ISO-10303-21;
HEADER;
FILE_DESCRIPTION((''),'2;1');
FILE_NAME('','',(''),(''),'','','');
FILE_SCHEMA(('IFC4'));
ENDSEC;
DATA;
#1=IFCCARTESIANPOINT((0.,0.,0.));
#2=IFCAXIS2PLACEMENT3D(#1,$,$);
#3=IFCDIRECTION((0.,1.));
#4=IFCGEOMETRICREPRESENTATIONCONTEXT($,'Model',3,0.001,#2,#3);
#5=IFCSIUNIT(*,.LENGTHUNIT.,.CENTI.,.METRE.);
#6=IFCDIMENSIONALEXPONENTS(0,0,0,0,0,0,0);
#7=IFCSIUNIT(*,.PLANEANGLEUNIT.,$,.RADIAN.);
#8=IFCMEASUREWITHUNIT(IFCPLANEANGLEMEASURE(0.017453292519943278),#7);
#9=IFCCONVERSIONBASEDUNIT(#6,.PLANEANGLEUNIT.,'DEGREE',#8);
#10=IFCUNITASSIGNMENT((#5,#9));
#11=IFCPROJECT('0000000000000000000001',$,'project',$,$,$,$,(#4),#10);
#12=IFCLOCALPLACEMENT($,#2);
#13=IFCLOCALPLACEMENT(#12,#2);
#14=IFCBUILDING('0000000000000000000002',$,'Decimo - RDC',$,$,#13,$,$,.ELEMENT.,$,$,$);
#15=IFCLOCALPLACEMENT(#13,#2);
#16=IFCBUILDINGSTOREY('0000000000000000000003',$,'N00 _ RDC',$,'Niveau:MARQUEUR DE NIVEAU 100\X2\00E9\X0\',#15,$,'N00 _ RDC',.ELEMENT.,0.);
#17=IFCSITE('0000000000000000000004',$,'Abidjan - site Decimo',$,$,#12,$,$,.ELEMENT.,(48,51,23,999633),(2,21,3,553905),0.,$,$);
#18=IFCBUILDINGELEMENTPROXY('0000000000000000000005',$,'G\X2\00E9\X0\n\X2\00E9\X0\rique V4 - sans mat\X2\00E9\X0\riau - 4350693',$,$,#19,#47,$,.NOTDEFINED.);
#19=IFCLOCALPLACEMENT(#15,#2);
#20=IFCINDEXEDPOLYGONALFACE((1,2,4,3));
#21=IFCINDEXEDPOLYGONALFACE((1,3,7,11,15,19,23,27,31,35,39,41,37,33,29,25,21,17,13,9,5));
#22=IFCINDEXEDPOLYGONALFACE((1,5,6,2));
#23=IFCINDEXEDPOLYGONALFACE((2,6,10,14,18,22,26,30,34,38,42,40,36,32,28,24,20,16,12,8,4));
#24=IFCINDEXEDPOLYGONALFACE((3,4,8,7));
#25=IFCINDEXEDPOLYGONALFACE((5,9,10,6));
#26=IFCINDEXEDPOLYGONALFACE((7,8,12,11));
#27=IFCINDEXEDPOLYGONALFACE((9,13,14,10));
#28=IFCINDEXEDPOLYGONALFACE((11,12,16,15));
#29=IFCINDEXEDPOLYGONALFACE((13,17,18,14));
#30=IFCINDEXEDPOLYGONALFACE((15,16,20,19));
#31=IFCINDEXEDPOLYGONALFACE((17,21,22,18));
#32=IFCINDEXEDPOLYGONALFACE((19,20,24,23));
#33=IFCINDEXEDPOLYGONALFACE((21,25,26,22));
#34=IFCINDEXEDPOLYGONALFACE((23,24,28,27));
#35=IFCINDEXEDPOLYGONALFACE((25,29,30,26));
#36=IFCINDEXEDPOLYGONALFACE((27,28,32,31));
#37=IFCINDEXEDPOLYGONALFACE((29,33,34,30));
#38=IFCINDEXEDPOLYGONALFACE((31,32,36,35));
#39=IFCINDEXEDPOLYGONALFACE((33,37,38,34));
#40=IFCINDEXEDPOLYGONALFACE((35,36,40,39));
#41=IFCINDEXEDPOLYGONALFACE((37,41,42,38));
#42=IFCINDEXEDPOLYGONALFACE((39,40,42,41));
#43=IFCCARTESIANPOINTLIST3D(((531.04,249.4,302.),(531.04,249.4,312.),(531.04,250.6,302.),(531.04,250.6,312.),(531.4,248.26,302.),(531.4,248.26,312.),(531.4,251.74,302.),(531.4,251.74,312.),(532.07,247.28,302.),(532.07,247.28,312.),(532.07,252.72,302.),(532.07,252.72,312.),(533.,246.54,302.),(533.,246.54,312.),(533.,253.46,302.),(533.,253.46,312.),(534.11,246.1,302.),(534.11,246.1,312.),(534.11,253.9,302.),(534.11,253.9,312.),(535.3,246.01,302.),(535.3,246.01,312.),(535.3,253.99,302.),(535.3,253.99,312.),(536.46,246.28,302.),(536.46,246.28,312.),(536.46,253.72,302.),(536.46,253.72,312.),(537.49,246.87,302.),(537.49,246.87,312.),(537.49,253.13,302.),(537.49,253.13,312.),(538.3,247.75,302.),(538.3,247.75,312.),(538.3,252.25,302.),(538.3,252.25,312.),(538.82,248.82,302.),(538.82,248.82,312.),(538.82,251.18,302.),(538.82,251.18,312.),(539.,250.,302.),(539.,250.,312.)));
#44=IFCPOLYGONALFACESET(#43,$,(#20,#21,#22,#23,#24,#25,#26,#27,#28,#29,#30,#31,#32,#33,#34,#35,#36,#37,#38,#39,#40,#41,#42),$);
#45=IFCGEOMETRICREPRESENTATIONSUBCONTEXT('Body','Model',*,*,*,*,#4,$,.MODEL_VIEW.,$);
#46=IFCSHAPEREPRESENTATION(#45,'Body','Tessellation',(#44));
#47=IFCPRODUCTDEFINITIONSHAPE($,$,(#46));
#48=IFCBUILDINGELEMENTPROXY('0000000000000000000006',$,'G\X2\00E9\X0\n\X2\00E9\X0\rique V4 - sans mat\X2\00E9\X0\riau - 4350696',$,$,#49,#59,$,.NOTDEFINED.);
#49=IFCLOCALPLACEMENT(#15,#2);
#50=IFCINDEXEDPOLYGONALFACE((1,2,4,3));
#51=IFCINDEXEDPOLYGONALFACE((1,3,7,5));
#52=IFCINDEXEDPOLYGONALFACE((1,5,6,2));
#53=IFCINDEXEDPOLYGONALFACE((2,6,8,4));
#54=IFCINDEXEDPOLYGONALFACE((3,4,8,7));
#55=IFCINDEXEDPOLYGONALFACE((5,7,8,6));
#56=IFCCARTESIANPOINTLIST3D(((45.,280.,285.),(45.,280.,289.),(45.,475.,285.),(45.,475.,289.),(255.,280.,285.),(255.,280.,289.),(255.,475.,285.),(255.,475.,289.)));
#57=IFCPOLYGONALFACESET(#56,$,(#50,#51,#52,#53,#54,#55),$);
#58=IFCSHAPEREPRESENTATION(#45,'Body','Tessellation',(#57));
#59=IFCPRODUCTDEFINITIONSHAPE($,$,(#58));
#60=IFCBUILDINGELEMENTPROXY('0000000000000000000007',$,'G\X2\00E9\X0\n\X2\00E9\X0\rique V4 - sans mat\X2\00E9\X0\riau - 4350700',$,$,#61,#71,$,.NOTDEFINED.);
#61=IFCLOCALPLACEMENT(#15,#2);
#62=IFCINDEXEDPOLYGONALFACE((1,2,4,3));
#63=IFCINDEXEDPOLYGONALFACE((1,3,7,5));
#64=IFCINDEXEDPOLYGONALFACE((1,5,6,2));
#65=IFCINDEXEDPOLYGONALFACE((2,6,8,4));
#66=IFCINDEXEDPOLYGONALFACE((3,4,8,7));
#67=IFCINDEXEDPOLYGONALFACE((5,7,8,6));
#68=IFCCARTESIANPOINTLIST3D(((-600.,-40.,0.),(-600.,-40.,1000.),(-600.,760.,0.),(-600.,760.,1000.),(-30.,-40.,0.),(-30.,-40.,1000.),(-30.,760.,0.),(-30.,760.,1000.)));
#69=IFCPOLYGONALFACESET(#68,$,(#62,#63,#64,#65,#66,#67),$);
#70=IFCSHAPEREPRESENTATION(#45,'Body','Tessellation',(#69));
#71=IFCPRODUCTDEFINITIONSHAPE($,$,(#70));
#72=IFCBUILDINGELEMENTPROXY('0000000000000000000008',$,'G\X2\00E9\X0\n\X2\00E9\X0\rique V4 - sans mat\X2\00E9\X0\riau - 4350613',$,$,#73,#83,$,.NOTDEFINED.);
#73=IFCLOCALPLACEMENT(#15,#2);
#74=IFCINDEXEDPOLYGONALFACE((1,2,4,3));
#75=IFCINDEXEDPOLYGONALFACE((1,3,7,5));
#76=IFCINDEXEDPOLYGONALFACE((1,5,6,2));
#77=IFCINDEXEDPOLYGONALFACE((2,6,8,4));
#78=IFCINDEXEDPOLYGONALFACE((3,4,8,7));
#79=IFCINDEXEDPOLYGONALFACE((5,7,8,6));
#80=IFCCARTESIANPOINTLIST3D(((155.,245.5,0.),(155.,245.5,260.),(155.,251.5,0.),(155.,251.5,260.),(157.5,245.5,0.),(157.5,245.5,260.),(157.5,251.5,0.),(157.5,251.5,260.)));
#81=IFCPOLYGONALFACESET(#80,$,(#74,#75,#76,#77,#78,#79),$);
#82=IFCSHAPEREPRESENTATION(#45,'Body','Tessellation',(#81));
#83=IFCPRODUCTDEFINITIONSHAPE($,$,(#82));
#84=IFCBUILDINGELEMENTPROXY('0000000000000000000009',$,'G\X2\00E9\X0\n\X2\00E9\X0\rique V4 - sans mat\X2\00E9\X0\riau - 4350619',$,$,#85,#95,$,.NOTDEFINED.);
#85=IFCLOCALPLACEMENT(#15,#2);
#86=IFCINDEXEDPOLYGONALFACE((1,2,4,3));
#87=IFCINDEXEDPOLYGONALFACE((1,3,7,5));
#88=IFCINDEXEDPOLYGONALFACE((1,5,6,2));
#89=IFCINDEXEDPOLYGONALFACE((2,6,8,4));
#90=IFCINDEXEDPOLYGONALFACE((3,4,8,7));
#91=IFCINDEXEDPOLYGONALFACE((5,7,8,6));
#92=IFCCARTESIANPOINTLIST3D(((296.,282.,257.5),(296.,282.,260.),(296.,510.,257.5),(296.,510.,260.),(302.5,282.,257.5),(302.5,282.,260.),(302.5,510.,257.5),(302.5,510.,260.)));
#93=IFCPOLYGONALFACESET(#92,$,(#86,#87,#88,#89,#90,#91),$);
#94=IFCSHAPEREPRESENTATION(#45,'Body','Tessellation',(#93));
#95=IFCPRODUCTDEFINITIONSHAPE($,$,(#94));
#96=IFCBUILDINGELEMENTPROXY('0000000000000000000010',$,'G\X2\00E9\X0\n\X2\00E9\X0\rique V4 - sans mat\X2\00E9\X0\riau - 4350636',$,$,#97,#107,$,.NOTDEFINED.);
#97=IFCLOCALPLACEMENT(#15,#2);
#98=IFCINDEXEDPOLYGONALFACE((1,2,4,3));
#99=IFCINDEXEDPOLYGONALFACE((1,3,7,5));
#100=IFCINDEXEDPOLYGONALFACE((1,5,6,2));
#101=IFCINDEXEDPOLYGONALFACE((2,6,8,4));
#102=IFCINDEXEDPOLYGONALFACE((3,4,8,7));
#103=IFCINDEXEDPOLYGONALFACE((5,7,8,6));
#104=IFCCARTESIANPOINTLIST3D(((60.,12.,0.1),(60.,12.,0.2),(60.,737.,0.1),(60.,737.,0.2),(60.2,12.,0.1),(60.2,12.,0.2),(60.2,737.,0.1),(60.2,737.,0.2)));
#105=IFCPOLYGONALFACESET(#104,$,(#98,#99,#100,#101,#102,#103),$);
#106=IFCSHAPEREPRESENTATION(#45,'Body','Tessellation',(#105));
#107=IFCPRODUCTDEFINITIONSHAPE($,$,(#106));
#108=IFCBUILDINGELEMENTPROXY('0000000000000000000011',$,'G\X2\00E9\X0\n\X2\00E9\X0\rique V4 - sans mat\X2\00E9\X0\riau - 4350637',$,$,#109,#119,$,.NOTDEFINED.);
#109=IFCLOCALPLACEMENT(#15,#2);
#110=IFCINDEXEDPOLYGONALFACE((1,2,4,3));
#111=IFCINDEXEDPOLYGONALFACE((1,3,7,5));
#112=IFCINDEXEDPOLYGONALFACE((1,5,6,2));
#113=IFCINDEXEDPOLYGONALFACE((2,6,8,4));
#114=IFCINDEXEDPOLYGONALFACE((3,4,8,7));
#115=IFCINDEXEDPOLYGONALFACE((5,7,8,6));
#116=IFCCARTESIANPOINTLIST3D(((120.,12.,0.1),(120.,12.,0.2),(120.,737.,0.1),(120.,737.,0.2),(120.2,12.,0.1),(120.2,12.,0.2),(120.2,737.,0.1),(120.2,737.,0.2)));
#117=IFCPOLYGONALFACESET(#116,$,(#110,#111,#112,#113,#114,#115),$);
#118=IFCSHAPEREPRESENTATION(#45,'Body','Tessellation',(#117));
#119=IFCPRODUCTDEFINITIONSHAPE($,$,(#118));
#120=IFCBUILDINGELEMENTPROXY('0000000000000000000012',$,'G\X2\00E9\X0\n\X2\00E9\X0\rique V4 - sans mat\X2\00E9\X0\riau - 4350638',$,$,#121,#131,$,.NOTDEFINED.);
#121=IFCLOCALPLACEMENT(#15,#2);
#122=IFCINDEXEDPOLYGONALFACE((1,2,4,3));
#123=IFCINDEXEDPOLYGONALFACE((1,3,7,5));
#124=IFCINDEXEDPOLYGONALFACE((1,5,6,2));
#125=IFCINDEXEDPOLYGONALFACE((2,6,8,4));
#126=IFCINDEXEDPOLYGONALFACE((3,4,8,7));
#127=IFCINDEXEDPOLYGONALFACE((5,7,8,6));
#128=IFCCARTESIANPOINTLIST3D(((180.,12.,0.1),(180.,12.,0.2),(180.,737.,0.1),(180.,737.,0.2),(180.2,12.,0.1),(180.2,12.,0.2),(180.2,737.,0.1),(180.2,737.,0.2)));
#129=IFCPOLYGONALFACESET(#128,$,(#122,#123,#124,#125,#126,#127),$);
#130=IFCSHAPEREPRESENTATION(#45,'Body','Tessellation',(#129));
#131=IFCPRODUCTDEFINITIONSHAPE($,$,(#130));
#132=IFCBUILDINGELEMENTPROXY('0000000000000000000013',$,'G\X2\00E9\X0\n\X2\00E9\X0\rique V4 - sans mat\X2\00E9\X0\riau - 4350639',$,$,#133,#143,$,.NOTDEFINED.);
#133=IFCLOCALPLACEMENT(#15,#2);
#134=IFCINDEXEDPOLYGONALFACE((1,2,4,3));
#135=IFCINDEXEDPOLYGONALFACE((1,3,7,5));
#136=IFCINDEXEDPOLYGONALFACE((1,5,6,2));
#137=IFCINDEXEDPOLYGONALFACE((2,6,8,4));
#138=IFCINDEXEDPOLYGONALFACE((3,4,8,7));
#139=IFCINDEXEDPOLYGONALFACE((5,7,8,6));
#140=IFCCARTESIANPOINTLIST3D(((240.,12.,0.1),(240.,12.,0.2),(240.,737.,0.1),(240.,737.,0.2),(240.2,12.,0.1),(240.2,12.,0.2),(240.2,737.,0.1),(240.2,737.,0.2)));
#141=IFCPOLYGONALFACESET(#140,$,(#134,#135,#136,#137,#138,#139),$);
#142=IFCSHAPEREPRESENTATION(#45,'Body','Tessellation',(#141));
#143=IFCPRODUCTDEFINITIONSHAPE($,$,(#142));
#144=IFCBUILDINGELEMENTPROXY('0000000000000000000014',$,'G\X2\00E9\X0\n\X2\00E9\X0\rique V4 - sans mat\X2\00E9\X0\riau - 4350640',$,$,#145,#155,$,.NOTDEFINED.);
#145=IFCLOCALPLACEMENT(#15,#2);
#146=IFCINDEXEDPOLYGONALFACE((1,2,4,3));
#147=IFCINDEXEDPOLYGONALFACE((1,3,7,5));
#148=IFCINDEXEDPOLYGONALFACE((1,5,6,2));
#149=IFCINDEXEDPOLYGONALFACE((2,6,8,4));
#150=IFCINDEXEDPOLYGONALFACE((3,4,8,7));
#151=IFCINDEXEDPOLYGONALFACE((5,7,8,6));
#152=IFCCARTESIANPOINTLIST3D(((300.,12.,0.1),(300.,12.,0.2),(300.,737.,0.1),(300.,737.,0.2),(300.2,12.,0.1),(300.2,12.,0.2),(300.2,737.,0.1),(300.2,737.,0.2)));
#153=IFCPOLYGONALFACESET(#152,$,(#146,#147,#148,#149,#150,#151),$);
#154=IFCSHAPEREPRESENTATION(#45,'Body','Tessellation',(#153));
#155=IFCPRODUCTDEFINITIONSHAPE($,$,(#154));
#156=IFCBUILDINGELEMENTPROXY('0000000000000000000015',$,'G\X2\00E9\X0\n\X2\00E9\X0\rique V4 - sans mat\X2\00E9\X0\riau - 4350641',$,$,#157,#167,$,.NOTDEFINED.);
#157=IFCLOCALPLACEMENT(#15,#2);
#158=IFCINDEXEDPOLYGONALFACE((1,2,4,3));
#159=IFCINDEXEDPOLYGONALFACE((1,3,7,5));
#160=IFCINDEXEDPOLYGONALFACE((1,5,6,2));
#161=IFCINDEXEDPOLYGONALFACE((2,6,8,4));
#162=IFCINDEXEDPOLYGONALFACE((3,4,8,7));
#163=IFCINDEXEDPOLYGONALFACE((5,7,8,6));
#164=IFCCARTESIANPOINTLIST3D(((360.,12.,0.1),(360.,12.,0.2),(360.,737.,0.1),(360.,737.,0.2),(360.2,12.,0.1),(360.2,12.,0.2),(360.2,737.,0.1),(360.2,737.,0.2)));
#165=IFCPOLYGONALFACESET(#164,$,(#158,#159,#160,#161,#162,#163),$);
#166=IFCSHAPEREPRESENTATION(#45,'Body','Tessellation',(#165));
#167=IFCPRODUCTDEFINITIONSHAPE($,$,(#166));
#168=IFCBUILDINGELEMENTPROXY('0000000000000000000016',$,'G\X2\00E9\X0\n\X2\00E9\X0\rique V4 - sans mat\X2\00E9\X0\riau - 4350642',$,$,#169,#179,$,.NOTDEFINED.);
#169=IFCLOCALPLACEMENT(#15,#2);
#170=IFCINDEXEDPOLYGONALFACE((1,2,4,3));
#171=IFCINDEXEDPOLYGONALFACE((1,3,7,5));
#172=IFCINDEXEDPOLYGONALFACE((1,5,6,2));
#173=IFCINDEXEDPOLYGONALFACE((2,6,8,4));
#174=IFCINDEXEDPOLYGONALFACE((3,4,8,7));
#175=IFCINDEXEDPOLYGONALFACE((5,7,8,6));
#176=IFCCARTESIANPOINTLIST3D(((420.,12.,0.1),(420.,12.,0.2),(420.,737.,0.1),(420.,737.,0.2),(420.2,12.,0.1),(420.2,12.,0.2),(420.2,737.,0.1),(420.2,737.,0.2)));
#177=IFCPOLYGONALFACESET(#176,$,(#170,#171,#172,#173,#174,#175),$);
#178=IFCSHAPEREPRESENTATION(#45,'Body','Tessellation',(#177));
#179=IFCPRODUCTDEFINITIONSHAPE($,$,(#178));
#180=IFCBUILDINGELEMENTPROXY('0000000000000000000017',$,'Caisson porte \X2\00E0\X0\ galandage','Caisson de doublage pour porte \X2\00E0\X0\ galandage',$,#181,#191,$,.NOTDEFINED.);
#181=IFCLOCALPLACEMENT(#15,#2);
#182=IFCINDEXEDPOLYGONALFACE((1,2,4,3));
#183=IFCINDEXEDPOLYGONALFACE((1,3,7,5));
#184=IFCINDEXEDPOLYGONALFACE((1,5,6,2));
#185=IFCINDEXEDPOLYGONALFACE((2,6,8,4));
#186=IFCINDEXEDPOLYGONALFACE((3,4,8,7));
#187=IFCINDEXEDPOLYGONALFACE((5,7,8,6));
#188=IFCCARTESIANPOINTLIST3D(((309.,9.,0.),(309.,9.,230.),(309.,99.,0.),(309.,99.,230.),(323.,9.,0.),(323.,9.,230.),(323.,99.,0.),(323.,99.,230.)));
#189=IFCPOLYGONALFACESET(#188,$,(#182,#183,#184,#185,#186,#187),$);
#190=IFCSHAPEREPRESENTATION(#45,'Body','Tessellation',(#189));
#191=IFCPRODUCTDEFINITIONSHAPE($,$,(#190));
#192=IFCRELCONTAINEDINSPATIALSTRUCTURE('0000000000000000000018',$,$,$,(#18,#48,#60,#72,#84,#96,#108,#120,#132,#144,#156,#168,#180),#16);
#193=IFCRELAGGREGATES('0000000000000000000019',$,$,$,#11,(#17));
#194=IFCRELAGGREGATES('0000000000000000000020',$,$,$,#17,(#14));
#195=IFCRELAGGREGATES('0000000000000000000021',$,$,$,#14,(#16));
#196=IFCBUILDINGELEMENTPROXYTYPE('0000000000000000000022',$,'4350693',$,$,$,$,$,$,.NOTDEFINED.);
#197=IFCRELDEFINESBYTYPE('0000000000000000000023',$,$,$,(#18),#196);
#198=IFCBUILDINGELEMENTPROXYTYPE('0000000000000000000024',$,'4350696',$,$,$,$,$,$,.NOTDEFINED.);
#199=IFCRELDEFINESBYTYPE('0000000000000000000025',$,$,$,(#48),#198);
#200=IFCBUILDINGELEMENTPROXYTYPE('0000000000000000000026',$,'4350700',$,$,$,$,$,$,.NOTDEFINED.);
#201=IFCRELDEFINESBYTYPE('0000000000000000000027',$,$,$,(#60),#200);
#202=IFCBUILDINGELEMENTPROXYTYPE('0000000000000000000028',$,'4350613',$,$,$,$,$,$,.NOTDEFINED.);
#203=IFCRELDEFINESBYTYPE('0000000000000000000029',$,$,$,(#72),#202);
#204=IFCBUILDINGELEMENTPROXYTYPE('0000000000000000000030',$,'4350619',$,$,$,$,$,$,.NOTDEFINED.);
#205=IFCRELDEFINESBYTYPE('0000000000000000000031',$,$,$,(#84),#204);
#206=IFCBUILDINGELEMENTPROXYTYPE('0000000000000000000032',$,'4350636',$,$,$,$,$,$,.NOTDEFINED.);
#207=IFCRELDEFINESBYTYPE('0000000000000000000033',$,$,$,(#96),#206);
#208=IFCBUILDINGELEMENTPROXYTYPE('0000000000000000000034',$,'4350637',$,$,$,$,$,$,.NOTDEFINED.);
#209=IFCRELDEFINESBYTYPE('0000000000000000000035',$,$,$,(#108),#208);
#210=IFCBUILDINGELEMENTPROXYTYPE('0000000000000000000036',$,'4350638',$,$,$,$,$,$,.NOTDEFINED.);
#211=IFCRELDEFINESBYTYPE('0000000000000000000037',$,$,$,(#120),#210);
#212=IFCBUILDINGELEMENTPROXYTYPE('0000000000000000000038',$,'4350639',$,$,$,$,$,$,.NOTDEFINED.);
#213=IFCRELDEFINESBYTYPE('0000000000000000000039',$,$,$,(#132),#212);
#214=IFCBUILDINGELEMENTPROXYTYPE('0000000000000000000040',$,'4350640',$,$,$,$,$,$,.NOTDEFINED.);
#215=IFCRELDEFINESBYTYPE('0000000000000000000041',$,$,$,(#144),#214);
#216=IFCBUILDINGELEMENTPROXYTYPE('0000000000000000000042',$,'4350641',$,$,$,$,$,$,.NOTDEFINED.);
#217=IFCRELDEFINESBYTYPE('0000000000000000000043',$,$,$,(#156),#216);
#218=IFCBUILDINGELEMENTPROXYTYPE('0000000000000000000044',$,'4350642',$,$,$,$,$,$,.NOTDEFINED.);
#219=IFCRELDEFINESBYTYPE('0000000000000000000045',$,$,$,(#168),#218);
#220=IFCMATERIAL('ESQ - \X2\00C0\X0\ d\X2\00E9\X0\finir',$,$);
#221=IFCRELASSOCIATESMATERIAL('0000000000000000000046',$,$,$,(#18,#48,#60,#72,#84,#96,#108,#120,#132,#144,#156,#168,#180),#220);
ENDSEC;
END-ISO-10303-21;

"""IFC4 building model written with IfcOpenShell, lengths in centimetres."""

from ifc_helpers import new_model, entity, si_unit, converted_unit, direction, frame, frame_2d, origin, origin_with_axes, origin_2d_with_axis, place, context, subcontext, project, spatial, rectangle, circle, extrude, material, type_object, element, save


model = new_model("IFC4")

# Units and contexts
model_context = context("Model", 3, precision=0.001, world=origin(), true_north=direction((0.0, 1.0)))
body_context = subcontext(model_context, "Body", "Model", "MODEL_VIEW")
ifc_project = project(units=[si_unit("LENGTHUNIT", "METRE", prefix="CENTI"), converted_unit("PLANEANGLEUNIT", "DEGREE", entity("IfcPlaneAngleMeasure", 0.017453292519943278), si_unit("PLANEANGLEUNIT", "RADIAN"), dimensions=[0, 0, 0, 0, 0, 0, 0])], contexts=[model_context])

# Site, building, storey
site_placement = place(None, origin())
site = spatial("IfcSite", under=ifc_project, at=site_placement, Name="Abidjan - site Decimo", CompositionType="ELEMENT", RefLatitude=(48, 51, 23, 999633), RefLongitude=(2, 21, 3, 553905), RefElevation=0.0)
building_placement = place(site_placement, origin())
building = spatial("IfcBuilding", under=site, at=building_placement, Name="Decimo - RDC", CompositionType="ELEMENT")
storey_placement = place(building_placement, origin())
storey = spatial("IfcBuildingStorey", under=building, at=storey_placement, Name="N00 _ RDC", ObjectType="Niveau:MARQUEUR DE NIVEAU 100é", LongName="N00 _ RDC", CompositionType="ELEMENT", Elevation=0.0)

# Building element proxies
ifc_material_1 = material(Name="ESQ - À définir")
building_element_proxy_type_1 = type_object("IfcBuildingElementProxyType", Name="4350693", PredefinedType="NOTDEFINED")
proxy_1_placement = place(storey_placement, origin())
element("IfcBuildingElementProxy", 1, at=proxy_1_placement, inside=storey, type_object=building_element_proxy_type_1, material=ifc_material_1, Name="Générique V4 - sans matériau - 4350693", PredefinedType="NOTDEFINED", context=body_context, shape_type="SweptSolid", body=[
    extrude(circle(Radius=4.0, at=origin_2d_with_axis()), frame((535.0, 250.0, 302.0)), (0.0, 0.0, 1.0), 10.0),
])
building_element_proxy_type_2 = type_object("IfcBuildingElementProxyType", Name="4350696", PredefinedType="NOTDEFINED")
proxy_2_placement = place(storey_placement, origin())
element("IfcBuildingElementProxy", 2, at=proxy_2_placement, inside=storey, type_object=building_element_proxy_type_2, material=ifc_material_1, Name="Générique V4 - sans matériau - 4350696", PredefinedType="NOTDEFINED", context=body_context, shape_type="SweptSolid", body=[
    extrude(rectangle(XDim=210.0, YDim=195.0, at=frame_2d((0.0, 0.0), x_axis=(1.0, 0.0))), frame((150.0, 377.5, 285.0)), (0.0, 0.0, 1.0), 4.0),
])
building_element_proxy_type_3 = type_object("IfcBuildingElementProxyType", Name="4350700", PredefinedType="NOTDEFINED")
proxy_3_placement = place(storey_placement, origin())
element("IfcBuildingElementProxy", 3, at=proxy_3_placement, inside=storey, type_object=building_element_proxy_type_3, material=ifc_material_1, Name="Générique V4 - sans matériau - 4350700", PredefinedType="NOTDEFINED", context=body_context, shape_type="SweptSolid", body=[
    extrude(rectangle(XDim=570.0, YDim=800.0, at=origin_2d_with_axis()), frame((-315.0, 360.0, 0.0)), (0.0, 0.0, 1.0), 1000.0),
])
building_element_proxy_type_4 = type_object("IfcBuildingElementProxyType", Name="4350613", PredefinedType="NOTDEFINED")
proxy_4_placement = place(storey_placement, origin())
element("IfcBuildingElementProxy", 4, at=proxy_4_placement, inside=storey, type_object=building_element_proxy_type_4, material=ifc_material_1, Name="Générique V4 - sans matériau - 4350613", PredefinedType="NOTDEFINED", context=body_context, shape_type="SweptSolid", body=[
    extrude(rectangle(XDim=2.5, YDim=6.0, at=frame_2d((0.0, 0.0), x_axis=(1.0, 0.0))), frame((156.25, 248.5, 0.0)), (0.0, 0.0, 1.0), 260.0),
])
building_element_proxy_type_5 = type_object("IfcBuildingElementProxyType", Name="4350619", PredefinedType="NOTDEFINED")
proxy_5_placement = place(storey_placement, origin())
element("IfcBuildingElementProxy", 5, at=proxy_5_placement, inside=storey, type_object=building_element_proxy_type_5, material=ifc_material_1, Name="Générique V4 - sans matériau - 4350619", PredefinedType="NOTDEFINED", context=body_context, shape_type="SweptSolid", body=[
    extrude(rectangle(XDim=6.5, YDim=228.0, at=frame_2d((0.0, 0.0), x_axis=(1.0, 0.0))), frame((299.25, 396.0, 257.5)), (0.0, 0.0, 1.0), 2.5),
])
building_element_proxy_type_6 = type_object("IfcBuildingElementProxyType", Name="4350636", PredefinedType="NOTDEFINED")
proxy_6_placement = place(storey_placement, origin())
element("IfcBuildingElementProxy", 6, at=proxy_6_placement, inside=storey, type_object=building_element_proxy_type_6, material=ifc_material_1, Name="Générique V4 - sans matériau - 4350636", PredefinedType="NOTDEFINED", context=body_context, shape_type="SweptSolid", body=[
    extrude(rectangle(XDim=0.2, YDim=725.0, at=frame_2d((0.0, 0.0), x_axis=(1.0, 0.0))), frame((60.1, 374.5, 0.1)), (0.0, 0.0, 1.0), 0.1),
])
building_element_proxy_type_7 = type_object("IfcBuildingElementProxyType", Name="4350637", PredefinedType="NOTDEFINED")
proxy_7_placement = place(storey_placement, origin())
element("IfcBuildingElementProxy", 7, at=proxy_7_placement, inside=storey, type_object=building_element_proxy_type_7, material=ifc_material_1, Name="Générique V4 - sans matériau - 4350637", PredefinedType="NOTDEFINED", context=body_context, shape_type="SweptSolid", body=[
    extrude(rectangle(XDim=0.2, YDim=725.0, at=frame_2d((0.0, 0.0), x_axis=(1.0, 0.0))), frame((120.1, 374.5, 0.1)), (0.0, 0.0, 1.0), 0.1),
])
building_element_proxy_type_8 = type_object("IfcBuildingElementProxyType", Name="4350638", PredefinedType="NOTDEFINED")
proxy_8_placement = place(storey_placement, origin())
element("IfcBuildingElementProxy", 8, at=proxy_8_placement, inside=storey, type_object=building_element_proxy_type_8, material=ifc_material_1, Name="Générique V4 - sans matériau - 4350638", PredefinedType="NOTDEFINED", context=body_context, shape_type="SweptSolid", body=[
    extrude(rectangle(XDim=0.2, YDim=725.0, at=origin_2d_with_axis()), frame((180.1, 374.5, 0.1)), (0.0, 0.0, 1.0), 0.1),
])
building_element_proxy_type_9 = type_object("IfcBuildingElementProxyType", Name="4350639", PredefinedType="NOTDEFINED")
proxy_9_placement = place(storey_placement, origin())
element("IfcBuildingElementProxy", 9, at=proxy_9_placement, inside=storey, type_object=building_element_proxy_type_9, material=ifc_material_1, Name="Générique V4 - sans matériau - 4350639", PredefinedType="NOTDEFINED", context=body_context, shape_type="SweptSolid", body=[
    extrude(rectangle(XDim=0.2, YDim=725.0, at=frame_2d((0.0, 0.0), x_axis=(1.0, 0.0))), frame((240.1, 374.5, 0.1)), (0.0, 0.0, 1.0), 0.1),
])
building_element_proxy_type_10 = type_object("IfcBuildingElementProxyType", Name="4350640", PredefinedType="NOTDEFINED")
proxy_10_placement = place(storey_placement, origin())
element("IfcBuildingElementProxy", 10, at=proxy_10_placement, inside=storey, type_object=building_element_proxy_type_10, material=ifc_material_1, Name="Générique V4 - sans matériau - 4350640", PredefinedType="NOTDEFINED", context=body_context, shape_type="SweptSolid", body=[
    extrude(rectangle(XDim=0.2, YDim=725.0, at=origin_2d_with_axis()), frame((300.1, 374.5, 0.1)), (0.0, 0.0, 1.0), 0.1),
])
building_element_proxy_type_11 = type_object("IfcBuildingElementProxyType", Name="4350641", PredefinedType="NOTDEFINED")
proxy_11_placement = place(storey_placement, origin())
element("IfcBuildingElementProxy", 11, at=proxy_11_placement, inside=storey, type_object=building_element_proxy_type_11, material=ifc_material_1, Name="Générique V4 - sans matériau - 4350641", PredefinedType="NOTDEFINED", context=body_context, shape_type="SweptSolid", body=[
    extrude(rectangle(XDim=0.2, YDim=725.0, at=origin_2d_with_axis()), frame((360.1, 374.5, 0.1)), (0.0, 0.0, 1.0), 0.1),
])
building_element_proxy_type_12 = type_object("IfcBuildingElementProxyType", Name="4350642", PredefinedType="NOTDEFINED")
proxy_12_placement = place(storey_placement, origin())
element("IfcBuildingElementProxy", 12, at=proxy_12_placement, inside=storey, type_object=building_element_proxy_type_12, material=ifc_material_1, Name="Générique V4 - sans matériau - 4350642", PredefinedType="NOTDEFINED", context=body_context, shape_type="SweptSolid", body=[
    extrude(rectangle(XDim=0.2, YDim=725.0, at=origin_2d_with_axis()), frame((420.1, 374.5, 0.1)), (0.0, 0.0, 1.0), 0.1),
])
proxy_13_placement = place(storey_placement, origin_with_axes())
element("IfcBuildingElementProxy", 13, at=proxy_13_placement, inside=storey, material=ifc_material_1, Name="Caisson porte à galandage", Description="Caisson de doublage pour porte à galandage", PredefinedType="NOTDEFINED", context=body_context, shape_type="SweptSolid", body=[
    extrude(rectangle(XDim=14.0, YDim=90.0, at=frame_2d((316.0, 54.0))), origin(), (0.0, 0.0, 1.0), 230.0),
])

save(model, "model.ifc")
